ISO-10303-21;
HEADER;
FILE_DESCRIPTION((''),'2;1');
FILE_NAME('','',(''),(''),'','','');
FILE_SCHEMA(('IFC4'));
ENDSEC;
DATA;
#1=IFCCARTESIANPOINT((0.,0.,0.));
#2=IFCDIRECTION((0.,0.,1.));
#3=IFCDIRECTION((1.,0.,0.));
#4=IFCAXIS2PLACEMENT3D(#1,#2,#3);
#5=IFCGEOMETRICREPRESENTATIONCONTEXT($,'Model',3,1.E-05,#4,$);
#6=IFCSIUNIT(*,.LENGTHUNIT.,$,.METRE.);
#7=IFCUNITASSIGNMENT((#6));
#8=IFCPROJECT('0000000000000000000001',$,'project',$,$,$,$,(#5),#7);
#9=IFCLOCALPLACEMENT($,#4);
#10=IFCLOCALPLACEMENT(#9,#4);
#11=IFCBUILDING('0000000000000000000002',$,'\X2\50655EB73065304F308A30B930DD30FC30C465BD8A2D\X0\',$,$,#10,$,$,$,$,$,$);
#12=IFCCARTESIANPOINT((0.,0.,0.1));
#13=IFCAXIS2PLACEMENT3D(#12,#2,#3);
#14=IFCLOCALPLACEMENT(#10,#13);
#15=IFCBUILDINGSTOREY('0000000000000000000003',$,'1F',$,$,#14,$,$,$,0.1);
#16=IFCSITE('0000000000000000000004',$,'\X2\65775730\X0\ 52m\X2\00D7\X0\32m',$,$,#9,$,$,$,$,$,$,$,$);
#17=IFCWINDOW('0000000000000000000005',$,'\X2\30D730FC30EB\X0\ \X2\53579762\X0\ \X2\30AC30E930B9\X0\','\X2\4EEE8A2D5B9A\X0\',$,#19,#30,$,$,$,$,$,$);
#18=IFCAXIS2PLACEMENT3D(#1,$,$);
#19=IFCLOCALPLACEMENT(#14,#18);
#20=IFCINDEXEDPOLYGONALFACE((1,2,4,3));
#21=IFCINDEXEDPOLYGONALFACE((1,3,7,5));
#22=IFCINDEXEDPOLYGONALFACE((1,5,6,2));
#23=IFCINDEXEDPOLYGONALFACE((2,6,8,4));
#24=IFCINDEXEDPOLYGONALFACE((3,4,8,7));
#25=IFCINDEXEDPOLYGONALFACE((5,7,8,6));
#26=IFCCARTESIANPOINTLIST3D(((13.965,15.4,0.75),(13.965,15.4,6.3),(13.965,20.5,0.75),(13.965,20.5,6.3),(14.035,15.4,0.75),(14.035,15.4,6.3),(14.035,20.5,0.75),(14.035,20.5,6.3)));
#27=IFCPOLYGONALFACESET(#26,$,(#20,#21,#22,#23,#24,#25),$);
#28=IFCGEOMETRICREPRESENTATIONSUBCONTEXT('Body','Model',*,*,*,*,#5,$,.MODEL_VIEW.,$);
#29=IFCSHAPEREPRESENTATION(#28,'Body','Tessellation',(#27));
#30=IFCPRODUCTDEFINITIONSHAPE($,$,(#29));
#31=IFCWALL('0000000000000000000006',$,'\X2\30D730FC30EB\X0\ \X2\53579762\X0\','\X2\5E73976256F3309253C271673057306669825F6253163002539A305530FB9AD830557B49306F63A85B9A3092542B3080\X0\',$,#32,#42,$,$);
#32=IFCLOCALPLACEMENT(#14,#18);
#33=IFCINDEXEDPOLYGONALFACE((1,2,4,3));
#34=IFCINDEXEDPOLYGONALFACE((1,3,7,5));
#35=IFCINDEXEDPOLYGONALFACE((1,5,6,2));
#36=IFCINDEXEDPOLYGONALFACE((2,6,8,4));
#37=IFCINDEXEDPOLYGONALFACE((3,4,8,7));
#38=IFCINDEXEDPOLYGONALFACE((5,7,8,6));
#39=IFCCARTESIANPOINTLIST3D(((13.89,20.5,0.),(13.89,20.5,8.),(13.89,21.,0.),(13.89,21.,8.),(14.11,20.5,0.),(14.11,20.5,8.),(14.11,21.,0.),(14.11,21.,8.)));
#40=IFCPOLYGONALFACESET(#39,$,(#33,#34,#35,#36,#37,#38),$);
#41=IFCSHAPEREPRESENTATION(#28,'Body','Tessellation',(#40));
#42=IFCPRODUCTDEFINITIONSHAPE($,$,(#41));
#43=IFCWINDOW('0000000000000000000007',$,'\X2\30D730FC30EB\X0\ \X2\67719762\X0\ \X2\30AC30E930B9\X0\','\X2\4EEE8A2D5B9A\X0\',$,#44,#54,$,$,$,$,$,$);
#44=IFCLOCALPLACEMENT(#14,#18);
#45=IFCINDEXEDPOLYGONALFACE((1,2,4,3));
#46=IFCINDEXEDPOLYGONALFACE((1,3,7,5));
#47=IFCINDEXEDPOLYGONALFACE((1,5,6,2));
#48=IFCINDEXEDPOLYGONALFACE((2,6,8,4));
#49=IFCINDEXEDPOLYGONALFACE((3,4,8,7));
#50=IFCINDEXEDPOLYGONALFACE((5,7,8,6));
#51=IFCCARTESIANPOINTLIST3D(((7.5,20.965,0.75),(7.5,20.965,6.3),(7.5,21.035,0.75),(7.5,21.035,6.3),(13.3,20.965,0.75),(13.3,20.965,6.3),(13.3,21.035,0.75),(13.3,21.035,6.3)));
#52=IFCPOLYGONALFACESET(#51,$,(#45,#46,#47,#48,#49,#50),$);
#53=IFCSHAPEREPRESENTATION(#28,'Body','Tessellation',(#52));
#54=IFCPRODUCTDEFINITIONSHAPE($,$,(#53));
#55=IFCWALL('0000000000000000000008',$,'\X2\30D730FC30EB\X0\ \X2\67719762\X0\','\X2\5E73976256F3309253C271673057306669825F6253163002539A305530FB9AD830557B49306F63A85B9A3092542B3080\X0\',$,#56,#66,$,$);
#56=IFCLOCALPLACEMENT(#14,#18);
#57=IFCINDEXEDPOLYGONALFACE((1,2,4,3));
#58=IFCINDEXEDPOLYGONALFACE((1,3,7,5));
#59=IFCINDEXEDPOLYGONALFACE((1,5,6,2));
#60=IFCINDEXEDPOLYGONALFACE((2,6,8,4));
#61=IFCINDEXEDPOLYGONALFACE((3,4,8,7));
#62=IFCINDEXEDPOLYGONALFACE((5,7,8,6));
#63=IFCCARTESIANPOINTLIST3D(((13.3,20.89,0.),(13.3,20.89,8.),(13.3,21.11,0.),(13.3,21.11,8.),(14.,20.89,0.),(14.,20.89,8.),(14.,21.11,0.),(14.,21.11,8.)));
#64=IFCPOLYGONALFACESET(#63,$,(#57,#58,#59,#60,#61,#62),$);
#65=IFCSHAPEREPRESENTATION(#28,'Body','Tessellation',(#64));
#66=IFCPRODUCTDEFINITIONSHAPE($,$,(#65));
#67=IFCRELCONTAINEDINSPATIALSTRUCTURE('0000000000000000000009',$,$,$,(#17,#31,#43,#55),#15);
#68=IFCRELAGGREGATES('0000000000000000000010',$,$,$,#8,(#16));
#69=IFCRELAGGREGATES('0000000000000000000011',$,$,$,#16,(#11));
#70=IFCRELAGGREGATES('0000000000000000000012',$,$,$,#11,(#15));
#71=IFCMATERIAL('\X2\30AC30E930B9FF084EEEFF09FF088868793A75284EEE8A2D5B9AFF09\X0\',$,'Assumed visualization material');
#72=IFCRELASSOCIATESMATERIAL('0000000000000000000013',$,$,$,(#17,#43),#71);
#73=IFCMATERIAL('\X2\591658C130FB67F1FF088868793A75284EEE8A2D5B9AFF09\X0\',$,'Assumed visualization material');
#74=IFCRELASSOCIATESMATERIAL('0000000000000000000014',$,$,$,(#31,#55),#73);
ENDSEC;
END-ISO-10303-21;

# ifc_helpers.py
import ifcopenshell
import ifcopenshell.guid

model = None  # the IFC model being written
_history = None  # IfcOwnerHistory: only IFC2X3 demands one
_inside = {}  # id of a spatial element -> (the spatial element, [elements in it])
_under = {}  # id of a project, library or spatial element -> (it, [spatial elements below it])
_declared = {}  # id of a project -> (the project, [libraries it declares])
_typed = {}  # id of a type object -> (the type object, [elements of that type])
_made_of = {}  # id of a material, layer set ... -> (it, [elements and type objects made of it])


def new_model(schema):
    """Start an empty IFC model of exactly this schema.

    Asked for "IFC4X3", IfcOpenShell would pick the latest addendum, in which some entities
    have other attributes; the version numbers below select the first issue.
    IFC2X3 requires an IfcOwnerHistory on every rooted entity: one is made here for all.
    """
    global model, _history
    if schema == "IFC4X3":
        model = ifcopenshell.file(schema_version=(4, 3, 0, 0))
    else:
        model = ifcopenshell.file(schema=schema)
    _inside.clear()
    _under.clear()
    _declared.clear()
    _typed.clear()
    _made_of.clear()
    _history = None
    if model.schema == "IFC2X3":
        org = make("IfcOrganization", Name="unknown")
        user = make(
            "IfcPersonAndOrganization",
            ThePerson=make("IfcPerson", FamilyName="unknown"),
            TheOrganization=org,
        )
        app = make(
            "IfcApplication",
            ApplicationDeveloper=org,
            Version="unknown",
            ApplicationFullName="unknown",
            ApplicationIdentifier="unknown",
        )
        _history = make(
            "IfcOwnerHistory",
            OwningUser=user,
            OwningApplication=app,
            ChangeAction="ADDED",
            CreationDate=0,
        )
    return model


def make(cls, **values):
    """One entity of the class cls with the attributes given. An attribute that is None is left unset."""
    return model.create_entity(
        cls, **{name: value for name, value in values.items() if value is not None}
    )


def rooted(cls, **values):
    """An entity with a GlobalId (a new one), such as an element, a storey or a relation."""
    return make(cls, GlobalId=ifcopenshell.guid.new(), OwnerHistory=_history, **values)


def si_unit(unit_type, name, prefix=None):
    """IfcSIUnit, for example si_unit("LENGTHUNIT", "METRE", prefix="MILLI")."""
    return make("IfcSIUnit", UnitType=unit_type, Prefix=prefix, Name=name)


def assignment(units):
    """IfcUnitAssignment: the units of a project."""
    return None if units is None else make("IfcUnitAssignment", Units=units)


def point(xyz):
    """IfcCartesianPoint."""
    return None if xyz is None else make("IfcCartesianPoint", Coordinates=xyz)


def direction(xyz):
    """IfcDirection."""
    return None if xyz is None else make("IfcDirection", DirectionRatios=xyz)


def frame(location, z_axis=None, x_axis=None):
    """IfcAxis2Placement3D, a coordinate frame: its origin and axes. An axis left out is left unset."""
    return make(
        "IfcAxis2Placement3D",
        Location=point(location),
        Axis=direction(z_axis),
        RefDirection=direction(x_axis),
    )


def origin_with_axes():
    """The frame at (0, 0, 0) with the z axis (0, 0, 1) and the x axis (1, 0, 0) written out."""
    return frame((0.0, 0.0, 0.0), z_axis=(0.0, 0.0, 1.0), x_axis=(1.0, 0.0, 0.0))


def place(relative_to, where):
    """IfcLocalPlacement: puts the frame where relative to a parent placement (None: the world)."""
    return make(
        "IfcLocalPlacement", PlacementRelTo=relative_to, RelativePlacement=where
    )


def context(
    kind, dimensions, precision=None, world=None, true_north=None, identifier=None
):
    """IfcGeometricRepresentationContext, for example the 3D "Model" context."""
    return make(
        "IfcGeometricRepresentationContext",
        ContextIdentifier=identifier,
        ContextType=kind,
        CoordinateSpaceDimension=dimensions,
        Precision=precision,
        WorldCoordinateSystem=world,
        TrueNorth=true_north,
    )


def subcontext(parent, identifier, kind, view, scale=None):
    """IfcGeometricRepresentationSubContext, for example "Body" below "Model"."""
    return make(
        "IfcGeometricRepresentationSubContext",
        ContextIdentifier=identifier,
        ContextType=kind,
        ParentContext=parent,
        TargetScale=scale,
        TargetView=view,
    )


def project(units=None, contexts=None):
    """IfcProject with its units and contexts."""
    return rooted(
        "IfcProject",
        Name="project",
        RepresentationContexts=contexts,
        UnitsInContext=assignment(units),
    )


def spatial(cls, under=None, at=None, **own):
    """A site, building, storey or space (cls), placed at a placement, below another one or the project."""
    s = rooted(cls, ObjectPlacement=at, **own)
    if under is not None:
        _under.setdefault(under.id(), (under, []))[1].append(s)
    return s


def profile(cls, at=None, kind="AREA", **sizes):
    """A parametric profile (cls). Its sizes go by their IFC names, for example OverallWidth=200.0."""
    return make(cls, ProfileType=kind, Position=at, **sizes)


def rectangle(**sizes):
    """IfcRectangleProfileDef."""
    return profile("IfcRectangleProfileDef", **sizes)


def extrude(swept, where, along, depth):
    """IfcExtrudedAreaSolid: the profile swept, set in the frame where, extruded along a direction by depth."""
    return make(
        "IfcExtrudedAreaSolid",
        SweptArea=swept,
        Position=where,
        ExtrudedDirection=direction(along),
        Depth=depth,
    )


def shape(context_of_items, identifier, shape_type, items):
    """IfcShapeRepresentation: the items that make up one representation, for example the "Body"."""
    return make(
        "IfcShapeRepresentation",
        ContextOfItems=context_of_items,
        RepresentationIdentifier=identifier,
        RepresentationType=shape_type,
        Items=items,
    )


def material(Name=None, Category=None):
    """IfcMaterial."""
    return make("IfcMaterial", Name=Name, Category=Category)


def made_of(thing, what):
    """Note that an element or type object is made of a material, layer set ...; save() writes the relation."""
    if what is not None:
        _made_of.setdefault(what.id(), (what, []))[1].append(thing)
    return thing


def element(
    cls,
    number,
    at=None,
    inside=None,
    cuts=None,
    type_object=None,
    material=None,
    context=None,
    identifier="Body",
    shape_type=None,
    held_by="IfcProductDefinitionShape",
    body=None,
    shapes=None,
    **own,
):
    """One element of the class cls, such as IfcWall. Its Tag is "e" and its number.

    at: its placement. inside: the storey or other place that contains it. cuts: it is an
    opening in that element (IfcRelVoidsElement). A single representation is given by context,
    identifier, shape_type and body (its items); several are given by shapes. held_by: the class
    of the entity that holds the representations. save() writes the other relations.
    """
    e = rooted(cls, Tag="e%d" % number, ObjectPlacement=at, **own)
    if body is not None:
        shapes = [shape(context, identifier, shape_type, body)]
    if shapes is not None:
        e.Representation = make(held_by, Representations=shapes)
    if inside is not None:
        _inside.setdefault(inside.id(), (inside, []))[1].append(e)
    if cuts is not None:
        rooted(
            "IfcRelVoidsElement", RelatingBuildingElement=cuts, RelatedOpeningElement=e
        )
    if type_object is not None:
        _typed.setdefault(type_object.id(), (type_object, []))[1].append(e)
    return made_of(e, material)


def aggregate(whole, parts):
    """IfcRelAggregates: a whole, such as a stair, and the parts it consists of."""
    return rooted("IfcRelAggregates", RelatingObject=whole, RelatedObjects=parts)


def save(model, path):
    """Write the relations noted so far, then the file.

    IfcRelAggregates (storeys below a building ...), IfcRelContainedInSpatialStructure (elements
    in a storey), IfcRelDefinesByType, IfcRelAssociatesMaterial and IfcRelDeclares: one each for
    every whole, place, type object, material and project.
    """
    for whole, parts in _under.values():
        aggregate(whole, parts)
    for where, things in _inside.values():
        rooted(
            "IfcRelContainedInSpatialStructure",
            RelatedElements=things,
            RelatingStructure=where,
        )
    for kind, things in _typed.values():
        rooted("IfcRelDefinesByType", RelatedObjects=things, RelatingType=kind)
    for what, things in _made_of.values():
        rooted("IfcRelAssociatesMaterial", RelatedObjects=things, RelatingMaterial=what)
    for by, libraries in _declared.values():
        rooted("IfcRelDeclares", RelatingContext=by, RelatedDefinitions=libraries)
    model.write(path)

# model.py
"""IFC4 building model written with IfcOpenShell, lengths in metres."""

from ifc_helpers import new_model, si_unit, frame, origin_with_axes, place, context, subcontext, project, spatial, rectangle, extrude, material, element, save


model = new_model("IFC4")

# Units and contexts
model_context = context("Model", 3, precision=1e-05, world=origin_with_axes())
body_context = subcontext(model_context, "Body", "Model", "MODEL_VIEW")
ifc_project = project(units=[si_unit("LENGTHUNIT", "METRE")], contexts=[model_context])

# Site, building, storey
site_placement = place(None, origin_with_axes())
site = spatial("IfcSite", under=ifc_project, at=site_placement, Name="敷地 52m×32m")
building_placement = place(site_placement, origin_with_axes())
building = spatial("IfcBuilding", under=site, at=building_placement, Name="健康づくりスポーツ施設")
storey_placement = place(building_placement, frame((0.0, 0.0, 0.1), z_axis=(0.0, 0.0, 1.0), x_axis=(1.0, 0.0, 0.0)))
storey = spatial("IfcBuildingStorey", under=building, at=storey_placement, Name="1F", Elevation=0.1)

# Shared definitions
ifc_material_1 = material(Name="外壁・柱（表示用仮設定）", Category="Assumed visualization material")

# Window
ifc_material_2 = material(Name="ガラス（仮）（表示用仮設定）", Category="Assumed visualization material")
window_1_placement = place(storey_placement, frame((14.0, 17.95, 0.75), z_axis=(0.0, 0.0, 1.0), x_axis=(1.0, 0.0, 0.0)))
element("IfcWindow", 1, at=window_1_placement, inside=storey, material=ifc_material_2, Name="プール 南面 ガラス", Description="仮設定", context=body_context, shape_type="SweptSolid", body=[
    extrude(rectangle(XDim=0.07, YDim=5.1), origin_with_axes(), (0.0, 0.0, 1.0), 5.55),
])

# Wall
wall_1_placement = place(storey_placement, frame((14.0, 20.75, 0.0), z_axis=(0.0, 0.0, 1.0), x_axis=(1.0, 0.0, 0.0)))
element("IfcWall", 2, at=wall_1_placement, inside=storey, material=ifc_material_1, Name="プール 南面", Description="平面図を参照して概形化。厚さ・高さ等は推定を含む", context=body_context, shape_type="SweptSolid", body=[
    extrude(rectangle(XDim=0.22, YDim=0.5), origin_with_axes(), (0.0, 0.0, 1.0), 8.0),
])

# Window
window_2_placement = place(storey_placement, frame((10.4, 21.0, 0.75), z_axis=(0.0, 0.0, 1.0), x_axis=(1.0, 0.0, 0.0)))
element("IfcWindow", 3, at=window_2_placement, inside=storey, material=ifc_material_2, Name="プール 東面 ガラス", Description="仮設定", context=body_context, shape_type="SweptSolid", body=[
    extrude(rectangle(XDim=5.8, YDim=0.07), origin_with_axes(), (0.0, 0.0, 1.0), 5.55),
])

# Wall
wall_2_placement = place(storey_placement, frame((13.65, 21.0, 0.0), z_axis=(0.0, 0.0, 1.0), x_axis=(1.0, 0.0, 0.0)))
element("IfcWall", 4, at=wall_2_placement, inside=storey, material=ifc_material_1, Name="プール 東面", Description="平面図を参照して概形化。厚さ・高さ等は推定を含む", context=body_context, shape_type="SweptSolid", body=[
    extrude(rectangle(XDim=0.7, YDim=0.22), origin_with_axes(), (0.0, 0.0, 1.0), 8.0),
])

save(model, "model.ifc")
